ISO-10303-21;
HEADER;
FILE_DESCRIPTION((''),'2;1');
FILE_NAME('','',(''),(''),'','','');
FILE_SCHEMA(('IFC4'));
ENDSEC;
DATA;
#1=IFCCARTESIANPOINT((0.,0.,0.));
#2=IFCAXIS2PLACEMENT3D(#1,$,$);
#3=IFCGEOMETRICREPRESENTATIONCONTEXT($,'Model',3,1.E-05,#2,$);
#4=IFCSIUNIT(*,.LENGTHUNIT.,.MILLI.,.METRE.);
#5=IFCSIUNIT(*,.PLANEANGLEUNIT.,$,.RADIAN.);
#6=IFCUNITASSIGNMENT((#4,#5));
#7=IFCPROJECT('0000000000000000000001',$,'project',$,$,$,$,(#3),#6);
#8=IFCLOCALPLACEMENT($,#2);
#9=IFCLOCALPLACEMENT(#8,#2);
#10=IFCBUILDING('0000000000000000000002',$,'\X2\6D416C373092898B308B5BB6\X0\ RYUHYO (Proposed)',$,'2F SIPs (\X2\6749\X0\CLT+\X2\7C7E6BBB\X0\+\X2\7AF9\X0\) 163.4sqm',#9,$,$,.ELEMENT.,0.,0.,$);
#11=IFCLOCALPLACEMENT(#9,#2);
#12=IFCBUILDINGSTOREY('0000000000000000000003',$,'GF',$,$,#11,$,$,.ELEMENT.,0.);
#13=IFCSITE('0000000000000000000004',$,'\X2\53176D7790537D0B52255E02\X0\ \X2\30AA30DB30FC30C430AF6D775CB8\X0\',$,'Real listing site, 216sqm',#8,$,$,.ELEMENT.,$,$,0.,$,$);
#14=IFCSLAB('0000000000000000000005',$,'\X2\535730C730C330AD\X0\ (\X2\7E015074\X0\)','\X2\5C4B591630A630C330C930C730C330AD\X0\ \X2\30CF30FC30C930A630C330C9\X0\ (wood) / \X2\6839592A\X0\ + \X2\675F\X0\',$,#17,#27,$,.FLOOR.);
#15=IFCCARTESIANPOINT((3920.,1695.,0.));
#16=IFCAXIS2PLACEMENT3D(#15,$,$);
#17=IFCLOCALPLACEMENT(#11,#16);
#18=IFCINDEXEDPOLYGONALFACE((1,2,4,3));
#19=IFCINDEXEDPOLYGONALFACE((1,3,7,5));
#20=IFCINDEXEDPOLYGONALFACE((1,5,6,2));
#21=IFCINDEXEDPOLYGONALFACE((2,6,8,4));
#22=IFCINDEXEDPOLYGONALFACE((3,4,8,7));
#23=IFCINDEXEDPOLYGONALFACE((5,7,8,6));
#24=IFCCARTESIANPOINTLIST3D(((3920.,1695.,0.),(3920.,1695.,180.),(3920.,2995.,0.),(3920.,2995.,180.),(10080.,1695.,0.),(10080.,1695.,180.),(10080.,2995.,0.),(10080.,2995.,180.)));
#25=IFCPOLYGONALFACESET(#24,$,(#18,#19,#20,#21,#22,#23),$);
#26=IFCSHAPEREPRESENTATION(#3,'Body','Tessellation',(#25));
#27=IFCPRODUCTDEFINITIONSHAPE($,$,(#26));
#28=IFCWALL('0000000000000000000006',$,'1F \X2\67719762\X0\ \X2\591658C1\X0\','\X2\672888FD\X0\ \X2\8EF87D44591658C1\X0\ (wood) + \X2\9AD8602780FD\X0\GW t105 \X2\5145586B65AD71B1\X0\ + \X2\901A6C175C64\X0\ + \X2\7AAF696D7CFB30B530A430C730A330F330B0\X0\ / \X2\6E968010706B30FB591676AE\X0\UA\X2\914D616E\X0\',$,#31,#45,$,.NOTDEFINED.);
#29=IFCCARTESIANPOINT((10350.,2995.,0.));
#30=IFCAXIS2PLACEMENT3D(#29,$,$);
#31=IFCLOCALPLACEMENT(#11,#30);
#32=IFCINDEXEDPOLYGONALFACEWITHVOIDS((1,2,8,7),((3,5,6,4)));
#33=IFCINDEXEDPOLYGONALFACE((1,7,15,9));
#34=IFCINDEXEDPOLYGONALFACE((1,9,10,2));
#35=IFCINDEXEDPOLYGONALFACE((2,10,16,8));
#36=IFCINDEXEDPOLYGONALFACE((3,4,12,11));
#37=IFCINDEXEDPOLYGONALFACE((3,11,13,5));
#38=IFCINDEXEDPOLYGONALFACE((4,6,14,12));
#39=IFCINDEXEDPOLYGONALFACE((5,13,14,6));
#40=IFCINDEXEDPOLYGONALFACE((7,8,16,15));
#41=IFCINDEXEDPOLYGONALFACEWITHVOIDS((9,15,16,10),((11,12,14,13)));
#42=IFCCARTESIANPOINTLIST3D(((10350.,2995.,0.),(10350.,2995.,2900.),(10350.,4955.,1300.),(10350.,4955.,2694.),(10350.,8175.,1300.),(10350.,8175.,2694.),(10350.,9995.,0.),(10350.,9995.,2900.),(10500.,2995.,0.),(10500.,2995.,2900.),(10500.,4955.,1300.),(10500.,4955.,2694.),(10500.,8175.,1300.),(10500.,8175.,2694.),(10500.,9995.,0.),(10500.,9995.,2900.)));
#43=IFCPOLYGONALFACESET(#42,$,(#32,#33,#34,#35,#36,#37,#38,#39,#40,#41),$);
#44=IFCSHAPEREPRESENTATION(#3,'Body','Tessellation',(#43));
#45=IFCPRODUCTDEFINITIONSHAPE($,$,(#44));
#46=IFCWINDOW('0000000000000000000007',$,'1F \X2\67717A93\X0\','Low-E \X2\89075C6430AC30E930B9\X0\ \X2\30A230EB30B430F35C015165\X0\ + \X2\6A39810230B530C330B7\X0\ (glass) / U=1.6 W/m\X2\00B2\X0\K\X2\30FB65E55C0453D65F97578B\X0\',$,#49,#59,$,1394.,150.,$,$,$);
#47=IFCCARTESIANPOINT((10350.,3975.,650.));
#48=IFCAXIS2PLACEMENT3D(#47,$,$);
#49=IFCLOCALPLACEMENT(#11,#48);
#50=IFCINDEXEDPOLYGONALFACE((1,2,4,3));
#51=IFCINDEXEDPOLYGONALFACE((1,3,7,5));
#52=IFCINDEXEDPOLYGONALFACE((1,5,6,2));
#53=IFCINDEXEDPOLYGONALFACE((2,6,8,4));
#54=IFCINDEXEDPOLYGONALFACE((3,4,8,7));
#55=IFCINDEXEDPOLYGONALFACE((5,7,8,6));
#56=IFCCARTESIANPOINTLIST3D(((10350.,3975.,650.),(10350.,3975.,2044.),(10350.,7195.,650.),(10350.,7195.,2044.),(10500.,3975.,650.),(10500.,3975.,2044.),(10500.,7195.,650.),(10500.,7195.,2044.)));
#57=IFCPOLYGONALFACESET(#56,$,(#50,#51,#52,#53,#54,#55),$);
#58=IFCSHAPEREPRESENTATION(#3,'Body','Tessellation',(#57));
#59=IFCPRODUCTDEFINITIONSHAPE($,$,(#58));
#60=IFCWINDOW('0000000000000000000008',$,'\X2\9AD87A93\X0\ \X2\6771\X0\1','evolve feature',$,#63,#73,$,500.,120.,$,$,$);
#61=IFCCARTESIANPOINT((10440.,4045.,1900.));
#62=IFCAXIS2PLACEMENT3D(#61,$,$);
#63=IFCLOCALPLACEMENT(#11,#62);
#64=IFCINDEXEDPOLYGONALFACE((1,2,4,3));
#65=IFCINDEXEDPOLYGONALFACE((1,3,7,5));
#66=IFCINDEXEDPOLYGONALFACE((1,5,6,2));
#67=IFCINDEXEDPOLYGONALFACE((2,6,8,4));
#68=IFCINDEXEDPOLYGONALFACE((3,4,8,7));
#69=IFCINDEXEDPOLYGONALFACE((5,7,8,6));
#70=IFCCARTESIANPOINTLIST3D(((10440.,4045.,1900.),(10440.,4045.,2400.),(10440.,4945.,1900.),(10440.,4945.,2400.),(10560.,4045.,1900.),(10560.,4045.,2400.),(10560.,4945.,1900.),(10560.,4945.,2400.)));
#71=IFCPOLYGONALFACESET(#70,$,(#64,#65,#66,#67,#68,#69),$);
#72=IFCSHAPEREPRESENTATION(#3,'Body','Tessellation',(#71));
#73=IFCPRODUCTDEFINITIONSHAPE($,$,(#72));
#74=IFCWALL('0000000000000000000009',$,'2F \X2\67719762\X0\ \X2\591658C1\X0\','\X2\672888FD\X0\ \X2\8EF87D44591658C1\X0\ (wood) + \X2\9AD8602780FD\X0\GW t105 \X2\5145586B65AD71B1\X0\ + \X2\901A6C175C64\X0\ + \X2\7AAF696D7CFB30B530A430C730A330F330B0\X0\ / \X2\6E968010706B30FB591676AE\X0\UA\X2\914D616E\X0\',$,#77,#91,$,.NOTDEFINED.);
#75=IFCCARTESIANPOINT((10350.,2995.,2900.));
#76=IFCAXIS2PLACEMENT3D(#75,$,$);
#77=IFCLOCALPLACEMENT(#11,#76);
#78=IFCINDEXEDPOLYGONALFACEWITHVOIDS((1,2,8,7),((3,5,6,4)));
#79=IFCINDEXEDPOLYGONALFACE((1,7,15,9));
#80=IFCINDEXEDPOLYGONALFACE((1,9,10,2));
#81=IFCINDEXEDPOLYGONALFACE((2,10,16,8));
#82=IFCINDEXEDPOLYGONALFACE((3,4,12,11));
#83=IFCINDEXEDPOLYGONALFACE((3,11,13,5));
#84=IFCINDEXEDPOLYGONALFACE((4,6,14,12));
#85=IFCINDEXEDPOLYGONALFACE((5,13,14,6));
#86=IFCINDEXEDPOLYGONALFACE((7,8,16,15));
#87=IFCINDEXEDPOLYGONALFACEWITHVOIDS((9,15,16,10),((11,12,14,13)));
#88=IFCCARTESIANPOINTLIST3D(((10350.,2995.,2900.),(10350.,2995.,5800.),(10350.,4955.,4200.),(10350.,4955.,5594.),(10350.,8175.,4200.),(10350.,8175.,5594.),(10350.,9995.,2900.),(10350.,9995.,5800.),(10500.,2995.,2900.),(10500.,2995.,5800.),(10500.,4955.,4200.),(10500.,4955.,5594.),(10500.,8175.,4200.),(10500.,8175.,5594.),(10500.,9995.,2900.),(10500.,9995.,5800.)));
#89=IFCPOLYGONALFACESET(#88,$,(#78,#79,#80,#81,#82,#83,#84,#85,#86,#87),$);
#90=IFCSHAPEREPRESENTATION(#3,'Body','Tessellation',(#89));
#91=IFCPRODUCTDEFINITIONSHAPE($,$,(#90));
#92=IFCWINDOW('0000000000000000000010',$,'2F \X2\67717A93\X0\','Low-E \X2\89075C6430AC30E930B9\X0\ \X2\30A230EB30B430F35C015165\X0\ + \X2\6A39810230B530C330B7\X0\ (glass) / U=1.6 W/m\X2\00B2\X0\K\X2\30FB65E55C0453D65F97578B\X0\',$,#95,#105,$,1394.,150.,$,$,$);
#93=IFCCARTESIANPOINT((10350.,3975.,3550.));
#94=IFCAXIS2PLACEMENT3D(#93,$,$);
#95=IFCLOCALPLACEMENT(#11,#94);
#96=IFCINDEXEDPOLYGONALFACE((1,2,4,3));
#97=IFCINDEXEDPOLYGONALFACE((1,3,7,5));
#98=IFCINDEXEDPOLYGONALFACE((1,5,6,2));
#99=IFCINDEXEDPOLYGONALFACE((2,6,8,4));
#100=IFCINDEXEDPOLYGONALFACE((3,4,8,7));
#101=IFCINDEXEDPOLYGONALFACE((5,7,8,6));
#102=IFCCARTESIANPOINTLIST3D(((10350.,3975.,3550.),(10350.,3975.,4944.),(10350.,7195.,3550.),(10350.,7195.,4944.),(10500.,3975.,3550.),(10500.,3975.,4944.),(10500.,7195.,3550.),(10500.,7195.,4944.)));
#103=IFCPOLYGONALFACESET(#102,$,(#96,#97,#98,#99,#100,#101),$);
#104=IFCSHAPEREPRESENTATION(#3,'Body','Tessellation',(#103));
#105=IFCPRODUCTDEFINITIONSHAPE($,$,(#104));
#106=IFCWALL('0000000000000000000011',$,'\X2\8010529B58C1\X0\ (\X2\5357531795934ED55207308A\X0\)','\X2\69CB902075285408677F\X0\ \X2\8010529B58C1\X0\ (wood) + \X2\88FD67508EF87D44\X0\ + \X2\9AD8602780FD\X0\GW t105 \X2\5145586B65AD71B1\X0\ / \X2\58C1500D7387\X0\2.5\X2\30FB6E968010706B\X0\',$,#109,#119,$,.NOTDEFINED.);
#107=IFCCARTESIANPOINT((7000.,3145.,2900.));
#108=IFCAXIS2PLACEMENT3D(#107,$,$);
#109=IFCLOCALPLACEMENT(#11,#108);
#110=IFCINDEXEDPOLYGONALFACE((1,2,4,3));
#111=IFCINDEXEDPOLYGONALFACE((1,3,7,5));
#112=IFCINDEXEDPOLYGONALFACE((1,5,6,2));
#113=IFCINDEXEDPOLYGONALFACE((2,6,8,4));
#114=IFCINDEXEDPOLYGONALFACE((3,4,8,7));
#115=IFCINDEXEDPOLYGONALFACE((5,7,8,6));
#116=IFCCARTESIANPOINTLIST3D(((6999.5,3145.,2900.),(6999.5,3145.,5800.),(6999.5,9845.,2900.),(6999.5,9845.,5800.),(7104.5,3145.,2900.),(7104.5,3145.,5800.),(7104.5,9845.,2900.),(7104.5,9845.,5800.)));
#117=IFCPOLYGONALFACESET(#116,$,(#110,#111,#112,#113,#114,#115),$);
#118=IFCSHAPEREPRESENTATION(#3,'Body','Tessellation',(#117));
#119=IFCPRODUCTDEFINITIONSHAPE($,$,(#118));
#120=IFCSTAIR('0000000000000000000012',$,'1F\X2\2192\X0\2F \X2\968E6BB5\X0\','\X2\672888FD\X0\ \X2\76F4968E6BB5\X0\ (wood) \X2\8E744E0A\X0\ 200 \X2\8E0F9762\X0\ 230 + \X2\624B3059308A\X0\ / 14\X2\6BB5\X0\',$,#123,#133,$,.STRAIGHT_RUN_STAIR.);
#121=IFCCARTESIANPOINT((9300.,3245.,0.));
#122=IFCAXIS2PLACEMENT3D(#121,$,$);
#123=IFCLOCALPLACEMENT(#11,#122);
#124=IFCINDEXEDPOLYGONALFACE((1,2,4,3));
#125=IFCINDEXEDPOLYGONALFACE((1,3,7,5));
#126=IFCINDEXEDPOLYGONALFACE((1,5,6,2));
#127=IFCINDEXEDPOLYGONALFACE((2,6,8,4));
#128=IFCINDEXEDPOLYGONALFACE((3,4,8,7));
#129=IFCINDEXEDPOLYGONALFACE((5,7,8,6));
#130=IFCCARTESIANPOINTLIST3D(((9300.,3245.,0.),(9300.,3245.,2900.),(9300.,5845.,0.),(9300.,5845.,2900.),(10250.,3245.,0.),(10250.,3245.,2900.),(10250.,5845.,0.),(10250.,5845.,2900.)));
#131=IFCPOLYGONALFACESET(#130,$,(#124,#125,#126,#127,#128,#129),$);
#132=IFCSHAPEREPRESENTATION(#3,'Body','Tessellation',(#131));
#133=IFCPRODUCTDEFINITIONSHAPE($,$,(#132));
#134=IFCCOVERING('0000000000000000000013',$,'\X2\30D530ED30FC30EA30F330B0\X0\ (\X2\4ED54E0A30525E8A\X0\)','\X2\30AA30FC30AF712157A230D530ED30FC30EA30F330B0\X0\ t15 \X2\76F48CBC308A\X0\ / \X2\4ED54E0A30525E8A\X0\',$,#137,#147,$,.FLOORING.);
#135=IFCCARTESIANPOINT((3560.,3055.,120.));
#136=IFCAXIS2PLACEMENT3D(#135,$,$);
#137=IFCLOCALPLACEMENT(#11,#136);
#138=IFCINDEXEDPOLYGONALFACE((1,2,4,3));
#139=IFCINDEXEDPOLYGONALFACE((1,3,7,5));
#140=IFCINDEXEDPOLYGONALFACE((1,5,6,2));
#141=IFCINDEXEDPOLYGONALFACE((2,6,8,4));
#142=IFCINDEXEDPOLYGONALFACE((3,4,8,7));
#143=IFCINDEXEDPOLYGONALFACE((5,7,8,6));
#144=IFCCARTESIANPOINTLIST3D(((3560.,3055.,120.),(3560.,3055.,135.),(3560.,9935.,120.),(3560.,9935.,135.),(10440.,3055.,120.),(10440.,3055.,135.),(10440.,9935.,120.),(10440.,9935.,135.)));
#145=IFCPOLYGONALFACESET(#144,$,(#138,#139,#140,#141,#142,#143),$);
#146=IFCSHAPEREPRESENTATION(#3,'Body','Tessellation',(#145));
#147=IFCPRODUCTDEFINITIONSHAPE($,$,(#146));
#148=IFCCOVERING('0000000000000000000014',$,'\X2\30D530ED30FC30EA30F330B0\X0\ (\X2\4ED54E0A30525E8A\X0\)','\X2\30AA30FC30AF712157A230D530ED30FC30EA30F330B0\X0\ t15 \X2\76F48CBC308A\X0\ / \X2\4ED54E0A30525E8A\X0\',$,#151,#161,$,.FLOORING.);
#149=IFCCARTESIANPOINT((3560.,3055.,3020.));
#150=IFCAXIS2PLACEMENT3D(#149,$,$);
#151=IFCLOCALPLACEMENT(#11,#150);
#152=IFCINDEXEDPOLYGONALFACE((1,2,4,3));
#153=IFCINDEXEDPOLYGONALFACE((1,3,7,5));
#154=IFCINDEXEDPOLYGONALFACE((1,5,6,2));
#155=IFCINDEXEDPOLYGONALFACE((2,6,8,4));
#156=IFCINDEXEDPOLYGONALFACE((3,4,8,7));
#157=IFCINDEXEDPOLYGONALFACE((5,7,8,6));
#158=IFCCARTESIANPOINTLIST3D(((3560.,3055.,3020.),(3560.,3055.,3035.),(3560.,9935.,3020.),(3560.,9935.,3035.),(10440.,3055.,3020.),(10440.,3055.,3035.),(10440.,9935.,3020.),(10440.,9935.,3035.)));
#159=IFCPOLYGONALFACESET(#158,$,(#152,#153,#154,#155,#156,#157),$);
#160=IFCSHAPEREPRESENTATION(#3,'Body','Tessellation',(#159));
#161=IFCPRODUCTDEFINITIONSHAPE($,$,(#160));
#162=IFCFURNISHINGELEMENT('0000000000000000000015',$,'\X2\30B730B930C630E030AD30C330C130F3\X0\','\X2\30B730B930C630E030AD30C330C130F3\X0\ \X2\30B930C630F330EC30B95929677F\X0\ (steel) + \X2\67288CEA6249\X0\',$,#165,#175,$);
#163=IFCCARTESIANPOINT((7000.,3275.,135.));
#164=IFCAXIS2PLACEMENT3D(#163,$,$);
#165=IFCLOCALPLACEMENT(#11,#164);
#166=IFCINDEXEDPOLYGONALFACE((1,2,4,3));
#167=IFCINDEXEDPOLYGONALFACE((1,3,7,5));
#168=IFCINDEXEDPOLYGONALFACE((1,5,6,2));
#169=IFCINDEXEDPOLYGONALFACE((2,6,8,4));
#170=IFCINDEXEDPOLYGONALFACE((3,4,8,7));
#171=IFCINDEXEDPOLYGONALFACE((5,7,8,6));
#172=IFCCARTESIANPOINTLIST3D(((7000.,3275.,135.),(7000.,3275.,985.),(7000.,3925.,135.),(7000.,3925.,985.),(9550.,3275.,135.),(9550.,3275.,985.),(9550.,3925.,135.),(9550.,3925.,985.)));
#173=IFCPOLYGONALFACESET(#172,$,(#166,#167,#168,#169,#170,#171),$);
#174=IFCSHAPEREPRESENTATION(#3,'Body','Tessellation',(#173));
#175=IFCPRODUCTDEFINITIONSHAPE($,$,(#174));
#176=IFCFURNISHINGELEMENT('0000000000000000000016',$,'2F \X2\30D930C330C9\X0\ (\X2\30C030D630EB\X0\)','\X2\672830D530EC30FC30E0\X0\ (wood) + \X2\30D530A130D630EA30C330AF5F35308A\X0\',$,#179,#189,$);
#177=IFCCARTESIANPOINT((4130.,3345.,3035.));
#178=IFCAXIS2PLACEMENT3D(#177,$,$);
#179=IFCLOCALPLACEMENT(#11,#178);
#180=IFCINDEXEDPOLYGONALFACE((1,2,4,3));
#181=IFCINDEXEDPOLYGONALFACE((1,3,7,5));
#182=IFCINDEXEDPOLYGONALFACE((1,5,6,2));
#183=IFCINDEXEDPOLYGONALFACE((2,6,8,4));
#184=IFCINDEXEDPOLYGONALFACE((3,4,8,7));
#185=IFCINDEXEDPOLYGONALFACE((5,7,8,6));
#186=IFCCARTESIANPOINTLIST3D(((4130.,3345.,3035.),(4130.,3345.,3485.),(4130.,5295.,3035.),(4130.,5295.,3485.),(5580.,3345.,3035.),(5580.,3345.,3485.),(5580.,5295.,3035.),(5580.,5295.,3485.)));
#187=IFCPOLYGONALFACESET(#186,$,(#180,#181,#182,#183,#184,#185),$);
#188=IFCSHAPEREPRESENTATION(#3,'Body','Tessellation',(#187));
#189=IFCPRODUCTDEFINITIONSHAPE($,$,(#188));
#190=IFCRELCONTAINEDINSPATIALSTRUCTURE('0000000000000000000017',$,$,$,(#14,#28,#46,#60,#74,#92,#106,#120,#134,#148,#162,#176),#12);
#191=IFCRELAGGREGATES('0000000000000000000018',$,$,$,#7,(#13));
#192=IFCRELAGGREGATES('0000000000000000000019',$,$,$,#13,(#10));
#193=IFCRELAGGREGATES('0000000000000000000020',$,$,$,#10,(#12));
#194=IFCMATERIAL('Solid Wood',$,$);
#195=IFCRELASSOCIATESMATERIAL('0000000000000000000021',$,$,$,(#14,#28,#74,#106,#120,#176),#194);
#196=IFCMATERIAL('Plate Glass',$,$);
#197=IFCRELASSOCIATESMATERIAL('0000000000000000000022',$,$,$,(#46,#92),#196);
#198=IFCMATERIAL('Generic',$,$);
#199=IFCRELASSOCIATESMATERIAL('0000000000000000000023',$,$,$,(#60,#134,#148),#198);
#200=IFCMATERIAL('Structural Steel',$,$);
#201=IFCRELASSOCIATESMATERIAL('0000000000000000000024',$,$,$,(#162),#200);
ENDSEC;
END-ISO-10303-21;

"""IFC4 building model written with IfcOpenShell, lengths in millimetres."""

from ifc_helpers import new_model, si_unit, frame, frame_2d, origin, place, context, project, spatial, rectangle, extrude, material, element, fill, save


model = new_model("IFC4")

# Units and contexts
model_context = context("Model", 3, precision=1e-05, world=origin())
ifc_project = project(units=[si_unit("LENGTHUNIT", "METRE", prefix="MILLI"), si_unit("PLANEANGLEUNIT", "RADIAN")], contexts=[model_context])

# Site, building, storey
site_placement = place(None, origin())
site = spatial("IfcSite", under=ifc_project, at=site_placement, Name="北海道紋別市 オホーツク海岸", ObjectType="Real listing site, 216sqm", CompositionType="ELEMENT", RefElevation=0.0)
building_placement = place(site_placement, origin())
building = spatial("IfcBuilding", under=site, at=building_placement, Name="流氷を見る家 RYUHYO (Proposed)", ObjectType="2F SIPs (杉CLT+籾殻+竹) 163.4sqm", CompositionType="ELEMENT", ElevationOfRefHeight=0.0, ElevationOfTerrain=0.0)
storey_placement = place(building_placement, origin())
storey = spatial("IfcBuildingStorey", under=building, at=storey_placement, Name="GF", CompositionType="ELEMENT", Elevation=0.0)

# Slab
ifc_material_1 = material(Name="Solid Wood")
slab_placement = place(storey_placement, frame((3920.0, 1695.0, 0.0)))
element("IfcSlab", 1, at=slab_placement, inside=storey, material=ifc_material_1, Name="南デッキ (縁側)", Description="屋外ウッドデッキ ハードウッド (wood) / 根太 + 束", PredefinedType="FLOOR", context=model_context, shape_type="SweptSolid", body=[
    extrude(rectangle(XDim=6160.0, YDim=1300.0, at=frame_2d((3080.0, 650.0))), frame((3920.0, 1695.0, 0.0)), (0.0, 0.0, 1.0), 180.0),
])

# Wall, openings, windows
wall_1_placement = place(storey_placement, frame((10350.0, 2995.0, 0.0)))
wall_1 = element("IfcWall", 2, at=wall_1_placement, inside=storey, material=ifc_material_1, Name="1F 東面 外壁", Description="木製 軸組外壁 (wood) + 高性能GW t105 充填断熱 + 通気層 + 窯業系サイディング / 準耐火・外皮UA配慮", PredefinedType="NOTDEFINED", context=model_context, shape_type="SweptSolid", body=[
    extrude(rectangle(XDim=150.0, YDim=7000.0, at=frame_2d((75.0, 3500.0))), frame((10350.0, 2995.0, 0.0)), (0.0, 0.0, 1.0), 2900.0),
])
opening_1_placement = place(storey_placement, frame((10350.0, 3975.0, 650.0)))
opening_1 = element("IfcOpeningElement", 3, at=opening_1_placement, cuts=wall_1, PredefinedType="NOTDEFINED", context=model_context, shape_type="SweptSolid", body=[
    extrude(rectangle(XDim=150.0, YDim=3220.0, at=frame_2d((75.0, 1610.0))), frame((10350.0, 3975.0, 650.0)), (0.0, 0.0, 1.0), 1394.0),
])
opening_2_placement = place(storey_placement, frame((10440.0, 4045.0, 1900.0)))
opening_2 = element("IfcOpeningElement", 4, at=opening_2_placement, cuts=wall_1, PredefinedType="NOTDEFINED", context=model_context, shape_type="SweptSolid", body=[
    extrude(rectangle(XDim=120.0, YDim=900.0, at=frame_2d((60.0, 450.0))), frame((10440.0, 4045.0, 1900.0)), (0.0, 0.0, 1.0), 500.0),
])
ifc_material_2 = material(Name="Plate Glass")
window_1_placement = place(storey_placement, frame((10350.0, 3975.0, 650.0)))
window_1 = element("IfcWindow", 5, at=window_1_placement, inside=storey, material=ifc_material_2, Name="1F 東窓", Description="Low-E 複層ガラス アルゴン封入 + 樹脂サッシ (glass) / U=1.6 W/m²K・日射取得型", OverallHeight=1394.0, OverallWidth=150.0, context=model_context, shape_type="SweptSolid", body=[
    extrude(rectangle(XDim=150.0, YDim=3220.0, at=frame_2d((75.0, 1610.0))), frame((10350.0, 3975.0, 650.0)), (0.0, 0.0, 1.0), 1394.0),
])
fill(opening_1, window_1)
ifc_material_3 = material(Name="Generic")
window_2_placement = place(storey_placement, frame((10440.0, 4045.0, 1900.0)))
window_2 = element("IfcWindow", 6, at=window_2_placement, inside=storey, material=ifc_material_3, Name="高窓 東1", Description="evolve feature", OverallHeight=500.0, OverallWidth=120.0, context=model_context, shape_type="SweptSolid", body=[
    extrude(rectangle(XDim=120.0, YDim=900.0, at=frame_2d((60.0, 450.0))), frame((10440.0, 4045.0, 1900.0)), (0.0, 0.0, 1.0), 500.0),
])
fill(opening_2, window_2)

# Wall, opening, window
wall_2_placement = place(storey_placement, frame((10350.0, 2995.0, 2900.0)))
wall_2 = element("IfcWall", 7, at=wall_2_placement, inside=storey, material=ifc_material_1, Name="2F 東面 外壁", Description="木製 軸組外壁 (wood) + 高性能GW t105 充填断熱 + 通気層 + 窯業系サイディング / 準耐火・外皮UA配慮", PredefinedType="NOTDEFINED", context=model_context, shape_type="SweptSolid", body=[
    extrude(rectangle(XDim=150.0, YDim=7000.0, at=frame_2d((75.0, 3500.0))), frame((10350.0, 2995.0, 2900.0)), (0.0, 0.0, 1.0), 2900.0),
])
opening_3_placement = place(storey_placement, frame((10350.0, 3975.0, 3550.0)))
opening_3 = element("IfcOpeningElement", 8, at=opening_3_placement, cuts=wall_2, PredefinedType="NOTDEFINED", context=model_context, shape_type="SweptSolid", body=[
    extrude(rectangle(XDim=150.0, YDim=3220.0, at=frame_2d((75.0, 1610.0))), frame((10350.0, 3975.0, 3550.0)), (0.0, 0.0, 1.0), 1394.0),
])
window_3_placement = place(storey_placement, frame((10350.0, 3975.0, 3550.0)))
window_3 = element("IfcWindow", 9, at=window_3_placement, inside=storey, material=ifc_material_2, Name="2F 東窓", Description="Low-E 複層ガラス アルゴン封入 + 樹脂サッシ (glass) / U=1.6 W/m²K・日射取得型", OverallHeight=1394.0, OverallWidth=150.0, context=model_context, shape_type="SweptSolid", body=[
    extrude(rectangle(XDim=150.0, YDim=3220.0, at=frame_2d((75.0, 1610.0))), frame((10350.0, 3975.0, 3550.0)), (0.0, 0.0, 1.0), 1394.0),
])
fill(opening_3, window_3)

# Wall
wall_3_placement = place(storey_placement, frame((7000.0, 3145.0, 2900.0)))
element("IfcWall", 10, at=wall_3_placement, inside=storey, material=ifc_material_1, Name="耐力壁 (南北間仕切り)", Description="構造用合板 耐力壁 (wood) + 製材軸組 + 高性能GW t105 充填断熱 / 壁倍率2.5・準耐火", PredefinedType="NOTDEFINED", context=model_context, shape_type="SweptSolid", body=[
    extrude(rectangle(XDim=105.0, YDim=6700.0, at=frame_2d((52.0, 3350.0))), frame((7000.0, 3145.0, 2900.0)), (0.0, 0.0, 1.0), 2900.0),
])

# Stair
stair_placement = place(storey_placement, frame((9300.0, 3245.0, 0.0)))
element("IfcStair", 11, at=stair_placement, inside=storey, material=ifc_material_1, Name="1F→2F 階段", Description="木製 直階段 (wood) 蹴上 200 踏面 230 + 手すり / 14段", PredefinedType="STRAIGHT_RUN_STAIR", context=model_context, shape_type="SweptSolid", body=[
    extrude(rectangle(XDim=950.0, YDim=2600.0, at=frame_2d((475.0, 1300.0))), frame((9300.0, 3245.0, 0.0)), (0.0, 0.0, 1.0), 2900.0),
])

# Coverings
covering_1_placement = place(storey_placement, frame((3560.0, 3055.0, 120.0)))
element("IfcCovering", 12, at=covering_1_placement, inside=storey, material=ifc_material_3, Name="フローリング (仕上げ床)", Description="オーク無垢フローリング t15 直貼り / 仕上げ床", PredefinedType="FLOORING", context=model_context, shape_type="SweptSolid", body=[
    extrude(rectangle(XDim=6880.0, YDim=6880.0, at=frame_2d((3440.0, 3440.0))), frame((3560.0, 3055.0, 120.0)), (0.0, 0.0, 1.0), 15.0),
])
covering_2_placement = place(storey_placement, frame((3560.0, 3055.0, 3020.0)))
element("IfcCovering", 13, at=covering_2_placement, inside=storey, material=ifc_material_3, Name="フローリング (仕上げ床)", Description="オーク無垢フローリング t15 直貼り / 仕上げ床", PredefinedType="FLOORING", context=model_context, shape_type="SweptSolid", body=[
    extrude(rectangle(XDim=6880.0, YDim=6880.0, at=frame_2d((3440.0, 3440.0))), frame((3560.0, 3055.0, 3020.0)), (0.0, 0.0, 1.0), 15.0),
])

# Furnishing elements
ifc_material_4 = material(Name="Structural Steel")
furnishing_1_placement = place(storey_placement, frame((7000.0, 3275.0, 135.0)))
element("IfcFurnishingElement", 14, at=furnishing_1_placement, inside=storey, material=ifc_material_4, Name="システムキッチン", Description="システムキッチン ステンレス天板 (steel) + 木質扉", context=model_context, shape_type="SweptSolid", body=[
    extrude(rectangle(XDim=2550.0, YDim=650.0, at=frame_2d((1275.0, 325.0))), frame((7000.0, 3275.0, 135.0)), (0.0, 0.0, 1.0), 850.0),
])
furnishing_2_placement = place(storey_placement, frame((4130.0, 3345.0, 3035.0)))
element("IfcFurnishingElement", 15, at=furnishing_2_placement, inside=storey, material=ifc_material_1, Name="2F ベッド (ダブル)", Description="木フレーム (wood) + ファブリック張り", context=model_context, shape_type="SweptSolid", body=[
    extrude(rectangle(XDim=1450.0, YDim=1950.0, at=frame_2d((725.0, 975.0))), frame((4130.0, 3345.0, 3035.0)), (0.0, 0.0, 1.0), 450.0),
])

save(model, "model.ifc")
